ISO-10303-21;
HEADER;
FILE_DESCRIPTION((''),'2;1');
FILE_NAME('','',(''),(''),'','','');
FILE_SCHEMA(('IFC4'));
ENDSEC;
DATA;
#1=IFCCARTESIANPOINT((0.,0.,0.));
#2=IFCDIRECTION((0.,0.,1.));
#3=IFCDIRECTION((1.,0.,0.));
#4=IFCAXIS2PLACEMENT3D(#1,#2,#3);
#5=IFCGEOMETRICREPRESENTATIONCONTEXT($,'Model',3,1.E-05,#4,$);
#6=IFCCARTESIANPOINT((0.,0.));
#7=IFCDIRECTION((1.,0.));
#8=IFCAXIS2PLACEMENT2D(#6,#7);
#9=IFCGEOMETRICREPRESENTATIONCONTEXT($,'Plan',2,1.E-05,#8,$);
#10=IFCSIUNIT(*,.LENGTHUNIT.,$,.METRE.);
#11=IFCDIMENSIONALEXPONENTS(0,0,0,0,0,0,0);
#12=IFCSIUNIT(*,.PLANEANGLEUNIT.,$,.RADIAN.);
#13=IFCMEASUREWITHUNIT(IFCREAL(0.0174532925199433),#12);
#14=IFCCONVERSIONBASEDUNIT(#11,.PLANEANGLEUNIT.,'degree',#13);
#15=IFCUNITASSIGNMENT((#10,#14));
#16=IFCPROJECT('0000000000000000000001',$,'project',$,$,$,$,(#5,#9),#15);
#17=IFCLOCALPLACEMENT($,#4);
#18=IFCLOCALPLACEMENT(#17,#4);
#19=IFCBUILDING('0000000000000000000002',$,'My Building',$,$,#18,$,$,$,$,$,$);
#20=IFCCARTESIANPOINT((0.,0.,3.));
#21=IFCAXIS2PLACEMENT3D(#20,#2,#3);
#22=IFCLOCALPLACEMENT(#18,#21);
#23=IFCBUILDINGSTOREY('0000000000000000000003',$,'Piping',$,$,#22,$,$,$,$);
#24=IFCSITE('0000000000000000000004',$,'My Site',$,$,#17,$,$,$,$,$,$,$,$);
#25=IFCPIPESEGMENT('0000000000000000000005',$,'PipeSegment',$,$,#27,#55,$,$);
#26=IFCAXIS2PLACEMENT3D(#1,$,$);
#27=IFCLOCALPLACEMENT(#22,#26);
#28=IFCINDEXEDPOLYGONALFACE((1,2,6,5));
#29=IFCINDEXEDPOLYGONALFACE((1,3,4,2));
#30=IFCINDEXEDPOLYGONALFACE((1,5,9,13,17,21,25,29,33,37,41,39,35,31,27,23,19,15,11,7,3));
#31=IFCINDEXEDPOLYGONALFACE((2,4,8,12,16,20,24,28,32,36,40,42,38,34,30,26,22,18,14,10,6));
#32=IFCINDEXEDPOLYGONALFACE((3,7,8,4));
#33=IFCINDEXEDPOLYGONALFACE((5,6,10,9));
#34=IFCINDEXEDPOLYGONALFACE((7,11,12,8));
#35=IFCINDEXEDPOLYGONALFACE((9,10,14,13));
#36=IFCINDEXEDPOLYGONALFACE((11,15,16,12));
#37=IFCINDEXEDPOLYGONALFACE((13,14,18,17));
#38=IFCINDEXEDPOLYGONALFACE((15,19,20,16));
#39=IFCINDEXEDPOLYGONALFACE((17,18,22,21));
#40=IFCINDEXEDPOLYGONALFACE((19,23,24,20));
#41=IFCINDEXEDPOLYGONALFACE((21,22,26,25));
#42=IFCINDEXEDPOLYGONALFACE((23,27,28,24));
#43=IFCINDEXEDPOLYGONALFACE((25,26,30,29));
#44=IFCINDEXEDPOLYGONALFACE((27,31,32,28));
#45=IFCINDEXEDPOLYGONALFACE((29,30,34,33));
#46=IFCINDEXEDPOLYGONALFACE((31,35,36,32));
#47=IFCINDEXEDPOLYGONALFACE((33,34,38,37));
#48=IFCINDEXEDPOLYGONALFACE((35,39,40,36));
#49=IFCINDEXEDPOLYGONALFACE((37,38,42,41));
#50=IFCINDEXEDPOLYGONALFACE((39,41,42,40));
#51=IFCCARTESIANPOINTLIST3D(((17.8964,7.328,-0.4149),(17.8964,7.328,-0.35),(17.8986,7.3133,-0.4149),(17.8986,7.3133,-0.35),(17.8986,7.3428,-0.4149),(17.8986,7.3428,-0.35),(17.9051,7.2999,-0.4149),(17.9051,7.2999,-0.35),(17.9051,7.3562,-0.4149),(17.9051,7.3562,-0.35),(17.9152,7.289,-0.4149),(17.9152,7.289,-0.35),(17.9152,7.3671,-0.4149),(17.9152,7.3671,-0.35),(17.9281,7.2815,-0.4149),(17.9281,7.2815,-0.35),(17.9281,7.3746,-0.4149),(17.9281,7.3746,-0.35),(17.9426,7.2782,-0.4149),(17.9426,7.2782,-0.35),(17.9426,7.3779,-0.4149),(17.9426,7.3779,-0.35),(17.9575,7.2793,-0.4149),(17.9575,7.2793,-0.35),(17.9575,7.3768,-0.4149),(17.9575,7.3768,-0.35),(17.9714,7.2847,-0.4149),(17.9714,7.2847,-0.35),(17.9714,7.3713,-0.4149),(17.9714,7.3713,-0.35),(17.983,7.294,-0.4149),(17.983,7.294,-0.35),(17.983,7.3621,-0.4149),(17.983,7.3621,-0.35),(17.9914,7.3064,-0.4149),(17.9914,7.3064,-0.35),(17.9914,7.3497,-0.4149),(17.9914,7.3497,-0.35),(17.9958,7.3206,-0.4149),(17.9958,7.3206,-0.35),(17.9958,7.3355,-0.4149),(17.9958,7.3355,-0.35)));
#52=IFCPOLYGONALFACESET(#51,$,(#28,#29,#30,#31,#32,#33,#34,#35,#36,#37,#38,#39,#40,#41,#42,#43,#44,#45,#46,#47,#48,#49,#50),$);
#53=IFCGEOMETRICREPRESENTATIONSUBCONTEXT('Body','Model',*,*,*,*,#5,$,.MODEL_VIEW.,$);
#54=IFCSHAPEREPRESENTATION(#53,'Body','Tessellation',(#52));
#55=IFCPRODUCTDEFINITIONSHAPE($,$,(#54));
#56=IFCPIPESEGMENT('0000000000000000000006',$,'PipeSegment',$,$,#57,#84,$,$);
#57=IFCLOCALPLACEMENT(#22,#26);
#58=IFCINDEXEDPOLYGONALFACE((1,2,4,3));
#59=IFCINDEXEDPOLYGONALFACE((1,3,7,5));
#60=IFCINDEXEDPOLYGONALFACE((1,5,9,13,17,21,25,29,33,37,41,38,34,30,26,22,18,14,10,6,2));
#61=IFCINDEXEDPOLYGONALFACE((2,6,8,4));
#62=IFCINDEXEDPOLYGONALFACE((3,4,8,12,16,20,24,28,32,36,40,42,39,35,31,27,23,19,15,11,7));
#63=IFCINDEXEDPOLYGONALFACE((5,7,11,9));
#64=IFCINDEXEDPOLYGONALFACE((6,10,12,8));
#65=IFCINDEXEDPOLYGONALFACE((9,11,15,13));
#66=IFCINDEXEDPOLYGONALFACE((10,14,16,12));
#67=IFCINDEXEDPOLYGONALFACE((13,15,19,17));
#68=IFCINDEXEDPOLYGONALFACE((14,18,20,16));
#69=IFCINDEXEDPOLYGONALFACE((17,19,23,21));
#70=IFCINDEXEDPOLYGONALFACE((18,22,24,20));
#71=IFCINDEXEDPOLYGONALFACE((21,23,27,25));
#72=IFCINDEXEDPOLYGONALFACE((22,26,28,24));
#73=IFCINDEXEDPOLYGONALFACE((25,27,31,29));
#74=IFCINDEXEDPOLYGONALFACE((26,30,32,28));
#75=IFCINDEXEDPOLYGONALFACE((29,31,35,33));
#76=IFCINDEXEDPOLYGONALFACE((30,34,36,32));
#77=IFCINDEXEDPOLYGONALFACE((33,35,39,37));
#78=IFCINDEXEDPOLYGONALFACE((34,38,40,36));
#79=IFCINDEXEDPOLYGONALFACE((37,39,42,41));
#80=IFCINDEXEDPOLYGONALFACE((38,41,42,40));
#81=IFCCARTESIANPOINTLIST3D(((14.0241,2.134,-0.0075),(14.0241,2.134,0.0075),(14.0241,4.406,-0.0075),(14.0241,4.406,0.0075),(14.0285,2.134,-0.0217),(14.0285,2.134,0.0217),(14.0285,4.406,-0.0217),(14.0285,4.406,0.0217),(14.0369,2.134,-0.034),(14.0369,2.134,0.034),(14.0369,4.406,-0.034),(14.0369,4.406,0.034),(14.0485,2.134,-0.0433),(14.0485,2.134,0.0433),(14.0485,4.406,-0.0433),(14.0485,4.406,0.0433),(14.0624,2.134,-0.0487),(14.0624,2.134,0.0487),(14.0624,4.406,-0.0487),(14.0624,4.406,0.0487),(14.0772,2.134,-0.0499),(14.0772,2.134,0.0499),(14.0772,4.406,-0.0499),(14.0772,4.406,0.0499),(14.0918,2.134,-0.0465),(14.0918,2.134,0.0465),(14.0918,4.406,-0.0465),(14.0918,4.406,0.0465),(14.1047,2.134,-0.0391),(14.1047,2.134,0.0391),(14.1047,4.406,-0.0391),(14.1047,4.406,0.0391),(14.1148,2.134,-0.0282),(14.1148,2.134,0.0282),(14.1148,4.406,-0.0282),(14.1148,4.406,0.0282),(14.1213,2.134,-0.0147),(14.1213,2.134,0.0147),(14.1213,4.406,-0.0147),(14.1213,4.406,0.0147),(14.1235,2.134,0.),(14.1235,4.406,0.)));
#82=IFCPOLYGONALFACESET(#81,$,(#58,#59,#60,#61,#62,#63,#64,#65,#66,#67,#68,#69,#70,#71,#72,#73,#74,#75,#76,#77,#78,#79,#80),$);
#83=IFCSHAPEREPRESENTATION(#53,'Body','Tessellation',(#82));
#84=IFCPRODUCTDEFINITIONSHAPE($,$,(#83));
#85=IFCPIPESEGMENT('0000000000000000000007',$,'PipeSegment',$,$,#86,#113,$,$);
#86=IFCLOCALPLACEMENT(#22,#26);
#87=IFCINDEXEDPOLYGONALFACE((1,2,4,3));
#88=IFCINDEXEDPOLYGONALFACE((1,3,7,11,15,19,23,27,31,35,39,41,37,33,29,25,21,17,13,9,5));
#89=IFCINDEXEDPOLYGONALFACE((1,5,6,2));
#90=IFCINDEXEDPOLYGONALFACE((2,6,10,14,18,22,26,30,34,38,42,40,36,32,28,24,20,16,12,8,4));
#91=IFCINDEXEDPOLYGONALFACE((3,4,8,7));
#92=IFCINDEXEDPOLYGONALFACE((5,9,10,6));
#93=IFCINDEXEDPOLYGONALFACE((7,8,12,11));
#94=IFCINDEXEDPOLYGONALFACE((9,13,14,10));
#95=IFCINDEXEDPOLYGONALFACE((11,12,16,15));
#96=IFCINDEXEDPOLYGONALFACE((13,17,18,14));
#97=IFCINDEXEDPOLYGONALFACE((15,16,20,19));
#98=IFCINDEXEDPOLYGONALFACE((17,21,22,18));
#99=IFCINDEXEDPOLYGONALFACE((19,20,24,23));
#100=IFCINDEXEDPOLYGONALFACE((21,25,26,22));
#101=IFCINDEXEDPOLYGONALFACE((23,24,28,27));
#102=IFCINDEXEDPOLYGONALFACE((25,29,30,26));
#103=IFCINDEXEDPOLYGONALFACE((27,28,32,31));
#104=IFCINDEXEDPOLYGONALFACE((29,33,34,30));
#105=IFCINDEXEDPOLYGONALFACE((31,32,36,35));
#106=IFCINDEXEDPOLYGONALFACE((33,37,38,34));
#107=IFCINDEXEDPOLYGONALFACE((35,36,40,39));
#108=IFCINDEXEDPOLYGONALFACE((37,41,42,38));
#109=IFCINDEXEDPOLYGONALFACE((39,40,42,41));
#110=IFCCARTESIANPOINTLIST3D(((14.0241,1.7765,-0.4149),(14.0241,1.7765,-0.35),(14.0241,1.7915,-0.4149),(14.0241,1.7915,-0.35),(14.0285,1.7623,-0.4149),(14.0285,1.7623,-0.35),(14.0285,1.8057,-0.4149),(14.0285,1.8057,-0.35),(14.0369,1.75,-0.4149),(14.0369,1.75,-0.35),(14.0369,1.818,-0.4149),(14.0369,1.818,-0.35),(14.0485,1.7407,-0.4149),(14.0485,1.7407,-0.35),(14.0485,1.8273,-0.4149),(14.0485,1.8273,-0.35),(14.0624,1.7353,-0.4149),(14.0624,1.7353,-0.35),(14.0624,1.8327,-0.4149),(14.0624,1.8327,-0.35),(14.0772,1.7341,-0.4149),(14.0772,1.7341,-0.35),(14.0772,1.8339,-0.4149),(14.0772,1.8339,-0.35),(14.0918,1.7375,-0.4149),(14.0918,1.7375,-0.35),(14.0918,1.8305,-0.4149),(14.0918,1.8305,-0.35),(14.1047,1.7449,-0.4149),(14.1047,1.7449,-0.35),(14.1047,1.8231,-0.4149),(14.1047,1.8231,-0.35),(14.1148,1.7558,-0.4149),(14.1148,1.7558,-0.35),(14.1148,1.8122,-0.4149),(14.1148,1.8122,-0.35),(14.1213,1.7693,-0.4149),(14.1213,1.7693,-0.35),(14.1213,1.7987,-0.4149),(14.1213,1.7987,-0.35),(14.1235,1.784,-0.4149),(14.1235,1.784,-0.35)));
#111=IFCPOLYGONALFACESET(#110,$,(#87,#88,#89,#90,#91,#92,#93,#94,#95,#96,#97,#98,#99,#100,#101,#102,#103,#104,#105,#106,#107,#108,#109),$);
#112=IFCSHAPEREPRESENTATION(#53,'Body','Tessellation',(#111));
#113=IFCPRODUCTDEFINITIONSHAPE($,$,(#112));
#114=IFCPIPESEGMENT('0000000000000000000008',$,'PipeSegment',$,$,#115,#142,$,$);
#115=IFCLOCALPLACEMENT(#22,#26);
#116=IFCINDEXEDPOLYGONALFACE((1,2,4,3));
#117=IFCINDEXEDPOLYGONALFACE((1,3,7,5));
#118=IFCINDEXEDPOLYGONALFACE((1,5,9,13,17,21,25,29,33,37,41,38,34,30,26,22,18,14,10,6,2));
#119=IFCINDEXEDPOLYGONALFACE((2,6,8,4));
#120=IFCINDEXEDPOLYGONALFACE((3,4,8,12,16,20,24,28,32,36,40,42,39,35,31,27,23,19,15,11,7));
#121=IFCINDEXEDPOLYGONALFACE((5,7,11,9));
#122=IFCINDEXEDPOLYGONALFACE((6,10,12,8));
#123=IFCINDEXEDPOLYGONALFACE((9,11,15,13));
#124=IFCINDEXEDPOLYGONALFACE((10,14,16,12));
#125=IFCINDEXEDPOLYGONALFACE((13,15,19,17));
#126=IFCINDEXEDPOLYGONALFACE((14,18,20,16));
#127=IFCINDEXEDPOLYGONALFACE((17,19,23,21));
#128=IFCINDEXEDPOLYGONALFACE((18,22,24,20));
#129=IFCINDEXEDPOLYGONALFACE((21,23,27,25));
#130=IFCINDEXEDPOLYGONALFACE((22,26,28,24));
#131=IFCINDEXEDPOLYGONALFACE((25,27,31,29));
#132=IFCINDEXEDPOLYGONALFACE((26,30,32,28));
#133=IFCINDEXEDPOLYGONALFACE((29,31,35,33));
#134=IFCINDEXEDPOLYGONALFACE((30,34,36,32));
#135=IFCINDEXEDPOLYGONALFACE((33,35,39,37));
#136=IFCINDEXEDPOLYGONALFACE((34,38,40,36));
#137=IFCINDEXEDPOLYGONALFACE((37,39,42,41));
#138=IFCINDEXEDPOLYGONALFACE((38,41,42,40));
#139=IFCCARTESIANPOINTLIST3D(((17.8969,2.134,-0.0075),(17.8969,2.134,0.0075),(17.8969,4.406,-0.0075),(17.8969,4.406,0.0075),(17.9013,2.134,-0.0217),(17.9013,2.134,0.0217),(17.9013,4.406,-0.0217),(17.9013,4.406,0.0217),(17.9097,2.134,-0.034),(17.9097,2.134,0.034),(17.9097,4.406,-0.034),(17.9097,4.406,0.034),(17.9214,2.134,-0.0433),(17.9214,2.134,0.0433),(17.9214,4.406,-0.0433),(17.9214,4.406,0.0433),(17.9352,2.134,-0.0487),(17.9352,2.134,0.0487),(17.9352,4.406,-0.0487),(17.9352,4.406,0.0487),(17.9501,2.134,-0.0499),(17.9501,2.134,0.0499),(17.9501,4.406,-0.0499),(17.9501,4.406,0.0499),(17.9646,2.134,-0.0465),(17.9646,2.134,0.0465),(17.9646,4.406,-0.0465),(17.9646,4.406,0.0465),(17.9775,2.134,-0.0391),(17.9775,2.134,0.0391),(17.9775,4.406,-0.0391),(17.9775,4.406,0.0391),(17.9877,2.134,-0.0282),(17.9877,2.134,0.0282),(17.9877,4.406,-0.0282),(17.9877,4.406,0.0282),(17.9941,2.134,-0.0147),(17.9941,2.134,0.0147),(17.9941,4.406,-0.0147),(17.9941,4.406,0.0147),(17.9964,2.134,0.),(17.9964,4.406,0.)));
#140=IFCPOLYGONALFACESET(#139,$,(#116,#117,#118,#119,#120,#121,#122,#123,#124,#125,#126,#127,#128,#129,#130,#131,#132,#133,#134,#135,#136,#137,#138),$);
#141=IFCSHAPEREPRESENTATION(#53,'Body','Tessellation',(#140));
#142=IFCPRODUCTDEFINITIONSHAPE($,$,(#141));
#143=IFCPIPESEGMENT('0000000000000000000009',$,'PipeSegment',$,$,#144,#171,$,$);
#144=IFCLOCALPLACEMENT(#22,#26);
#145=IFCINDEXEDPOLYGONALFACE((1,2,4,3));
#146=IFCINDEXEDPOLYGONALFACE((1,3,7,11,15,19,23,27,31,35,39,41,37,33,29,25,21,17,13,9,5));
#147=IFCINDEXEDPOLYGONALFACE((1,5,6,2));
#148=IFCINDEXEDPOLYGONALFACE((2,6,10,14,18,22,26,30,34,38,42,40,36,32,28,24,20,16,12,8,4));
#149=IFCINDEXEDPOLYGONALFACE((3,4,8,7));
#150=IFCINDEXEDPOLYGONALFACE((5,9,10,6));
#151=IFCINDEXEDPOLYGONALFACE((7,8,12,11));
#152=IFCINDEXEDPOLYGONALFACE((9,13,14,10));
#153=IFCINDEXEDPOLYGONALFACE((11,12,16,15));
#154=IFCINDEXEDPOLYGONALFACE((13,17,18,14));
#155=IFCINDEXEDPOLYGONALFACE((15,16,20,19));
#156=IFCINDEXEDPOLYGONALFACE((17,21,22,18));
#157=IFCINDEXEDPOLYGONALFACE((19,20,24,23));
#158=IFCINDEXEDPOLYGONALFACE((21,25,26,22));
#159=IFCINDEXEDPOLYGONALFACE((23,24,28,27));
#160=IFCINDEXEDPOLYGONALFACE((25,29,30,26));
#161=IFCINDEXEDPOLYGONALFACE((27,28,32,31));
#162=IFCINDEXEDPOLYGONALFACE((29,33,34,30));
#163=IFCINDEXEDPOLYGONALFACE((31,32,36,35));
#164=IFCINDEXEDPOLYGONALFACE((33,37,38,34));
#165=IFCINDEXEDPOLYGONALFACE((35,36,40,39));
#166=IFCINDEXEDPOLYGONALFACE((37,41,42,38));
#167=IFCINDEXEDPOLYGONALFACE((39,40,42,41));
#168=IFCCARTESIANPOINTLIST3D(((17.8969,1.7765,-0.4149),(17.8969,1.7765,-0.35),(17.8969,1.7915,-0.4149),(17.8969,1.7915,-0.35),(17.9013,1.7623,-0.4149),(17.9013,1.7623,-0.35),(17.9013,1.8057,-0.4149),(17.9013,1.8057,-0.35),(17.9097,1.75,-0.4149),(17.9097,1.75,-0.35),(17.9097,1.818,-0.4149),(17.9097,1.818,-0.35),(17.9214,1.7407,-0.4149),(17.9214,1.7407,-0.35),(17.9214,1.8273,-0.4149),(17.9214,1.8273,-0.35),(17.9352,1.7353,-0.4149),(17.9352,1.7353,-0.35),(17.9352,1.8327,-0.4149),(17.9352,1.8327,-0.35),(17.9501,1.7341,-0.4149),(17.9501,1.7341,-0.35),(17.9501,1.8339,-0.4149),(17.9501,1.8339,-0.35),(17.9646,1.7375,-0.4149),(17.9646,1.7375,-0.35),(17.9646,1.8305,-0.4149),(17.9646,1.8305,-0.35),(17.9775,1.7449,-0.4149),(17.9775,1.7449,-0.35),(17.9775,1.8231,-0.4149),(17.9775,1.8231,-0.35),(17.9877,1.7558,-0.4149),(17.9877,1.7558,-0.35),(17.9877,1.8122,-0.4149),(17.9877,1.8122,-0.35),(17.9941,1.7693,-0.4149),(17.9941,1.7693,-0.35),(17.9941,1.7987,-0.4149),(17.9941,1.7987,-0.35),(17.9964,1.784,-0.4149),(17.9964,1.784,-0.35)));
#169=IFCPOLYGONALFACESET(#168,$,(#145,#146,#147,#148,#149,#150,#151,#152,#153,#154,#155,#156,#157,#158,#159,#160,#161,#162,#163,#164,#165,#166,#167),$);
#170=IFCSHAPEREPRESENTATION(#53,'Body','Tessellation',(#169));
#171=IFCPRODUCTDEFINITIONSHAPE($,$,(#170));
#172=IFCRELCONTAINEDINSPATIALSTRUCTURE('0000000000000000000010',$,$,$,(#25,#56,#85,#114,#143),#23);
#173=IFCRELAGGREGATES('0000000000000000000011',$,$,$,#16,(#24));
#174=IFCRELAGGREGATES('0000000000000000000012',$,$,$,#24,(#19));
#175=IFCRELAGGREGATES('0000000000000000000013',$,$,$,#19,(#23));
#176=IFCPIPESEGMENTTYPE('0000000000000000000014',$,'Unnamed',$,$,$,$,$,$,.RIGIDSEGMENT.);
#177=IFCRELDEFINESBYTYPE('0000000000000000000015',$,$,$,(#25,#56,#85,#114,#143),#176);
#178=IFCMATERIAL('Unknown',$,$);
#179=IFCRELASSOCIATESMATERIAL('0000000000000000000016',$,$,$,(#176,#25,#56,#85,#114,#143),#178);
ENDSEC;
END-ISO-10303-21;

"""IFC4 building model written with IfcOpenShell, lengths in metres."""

from ifc_helpers import new_model, entity, si_unit, converted_unit, frame, origin_with_axes, origin_2d_with_axis, place, context, subcontext, project, spatial, circle, extrude, material, material_profile, profile_set, profile_usage, type_object, element, save


model = new_model("IFC4")

# Units and contexts
model_context = context("Model", 3, precision=1e-05, world=origin_with_axes())
plan_context = context("Plan", 2, precision=1e-05, world=origin_2d_with_axis())
body_context = subcontext(model_context, "Body", "Model", "MODEL_VIEW")
ifc_project = project(units=[si_unit("LENGTHUNIT", "METRE"), converted_unit("PLANEANGLEUNIT", "degree", entity("IfcReal", 0.0174532925199433), si_unit("PLANEANGLEUNIT", "RADIAN"), dimensions=[0, 0, 0, 0, 0, 0, 0])], contexts=[model_context, plan_context])

# Site, building, storey
site_placement = place(None, origin_with_axes())
site = spatial("IfcSite", under=ifc_project, at=site_placement, Name="My Site")
building_placement = place(site_placement, origin_with_axes())
building = spatial("IfcBuilding", under=site, at=building_placement, Name="My Building")
storey_placement = place(building_placement, frame((0.0, 0.0, 3.0), z_axis=(0.0, 0.0, 1.0), x_axis=(1.0, 0.0, 0.0)))
storey = spatial("IfcBuildingStorey", under=building, at=storey_placement, Name="Piping")

# Pipe segments
ifc_material = material(Name="Unknown")
ifc_material_profile_1 = material_profile(ifc_material, circle(Radius=0.05))
ifc_profile_set_1 = profile_set([ifc_material_profile_1])
pipe_segment_type = type_object("IfcPipeSegmentType", Name="Unnamed", PredefinedType="RIGIDSEGMENT", material=ifc_profile_set_1)
ifc_profile_usage_1 = profile_usage(ifc_profile_set_1, cardinal=5)
pipe_segment_1_placement = place(storey_placement, frame((17.9464, 7.328, -0.35), z_axis=(0.0, 0.0, -1.0), x_axis=(-1.0, 0.0, 0.0)))
element("IfcPipeSegment", 1, at=pipe_segment_1_placement, inside=storey, type_object=pipe_segment_type, material=ifc_profile_usage_1, Name="PipeSegment", context=body_context, shape_type="SweptSolid", body=[
    extrude(circle(Radius=0.05), origin_with_axes(), (0.0, 0.0, 1.0), 0.0649),
])
ifc_profile_usage_2 = profile_usage(ifc_profile_set_1, cardinal=5)
pipe_segment_2_placement = place(storey_placement, frame((14.0735, 4.406, 0.0), z_axis=(0.0, -1.0, 0.0), x_axis=(1.0, 0.0, 0.0)))
element("IfcPipeSegment", 2, at=pipe_segment_2_placement, inside=storey, type_object=pipe_segment_type, material=ifc_profile_usage_2, Name="PipeSegment", context=body_context, shape_type="SweptSolid", body=[
    extrude(circle(Radius=0.05), origin_with_axes(), (0.0, 0.0, 1.0), 2.272),
])
ifc_profile_usage_3 = profile_usage(ifc_profile_set_1, cardinal=5)
pipe_segment_3_placement = place(storey_placement, frame((14.0735, 1.784, -0.35), z_axis=(0.0, 0.0, -1.0), x_axis=(1.0, 0.0, 0.0)))
element("IfcPipeSegment", 3, at=pipe_segment_3_placement, inside=storey, type_object=pipe_segment_type, material=ifc_profile_usage_3, Name="PipeSegment", context=body_context, shape_type="SweptSolid", body=[
    extrude(circle(Radius=0.05), origin_with_axes(), (0.0, 0.0, 1.0), 0.0649),
])
ifc_profile_usage_4 = profile_usage(ifc_profile_set_1, cardinal=5)
pipe_segment_4_placement = place(storey_placement, frame((17.9464, 4.406, 0.0), z_axis=(0.0, -1.0, 0.0), x_axis=(1.0, 0.0, 0.0)))
element("IfcPipeSegment", 4, at=pipe_segment_4_placement, inside=storey, type_object=pipe_segment_type, material=ifc_profile_usage_4, Name="PipeSegment", context=body_context, shape_type="SweptSolid", body=[
    extrude(circle(Radius=0.05), origin_with_axes(), (0.0, 0.0, 1.0), 2.272),
])
ifc_profile_usage_5 = profile_usage(ifc_profile_set_1, cardinal=5)
pipe_segment_5_placement = place(storey_placement, frame((17.9464, 1.784, -0.35), z_axis=(0.0, 0.0, -1.0), x_axis=(1.0, 0.0, 0.0)))
element("IfcPipeSegment", 5, at=pipe_segment_5_placement, inside=storey, type_object=pipe_segment_type, material=ifc_profile_usage_5, Name="PipeSegment", context=body_context, shape_type="SweptSolid", body=[
    extrude(circle(Radius=0.05), origin_with_axes(), (0.0, 0.0, 1.0), 0.0649),
])

save(model, "model.ifc")
